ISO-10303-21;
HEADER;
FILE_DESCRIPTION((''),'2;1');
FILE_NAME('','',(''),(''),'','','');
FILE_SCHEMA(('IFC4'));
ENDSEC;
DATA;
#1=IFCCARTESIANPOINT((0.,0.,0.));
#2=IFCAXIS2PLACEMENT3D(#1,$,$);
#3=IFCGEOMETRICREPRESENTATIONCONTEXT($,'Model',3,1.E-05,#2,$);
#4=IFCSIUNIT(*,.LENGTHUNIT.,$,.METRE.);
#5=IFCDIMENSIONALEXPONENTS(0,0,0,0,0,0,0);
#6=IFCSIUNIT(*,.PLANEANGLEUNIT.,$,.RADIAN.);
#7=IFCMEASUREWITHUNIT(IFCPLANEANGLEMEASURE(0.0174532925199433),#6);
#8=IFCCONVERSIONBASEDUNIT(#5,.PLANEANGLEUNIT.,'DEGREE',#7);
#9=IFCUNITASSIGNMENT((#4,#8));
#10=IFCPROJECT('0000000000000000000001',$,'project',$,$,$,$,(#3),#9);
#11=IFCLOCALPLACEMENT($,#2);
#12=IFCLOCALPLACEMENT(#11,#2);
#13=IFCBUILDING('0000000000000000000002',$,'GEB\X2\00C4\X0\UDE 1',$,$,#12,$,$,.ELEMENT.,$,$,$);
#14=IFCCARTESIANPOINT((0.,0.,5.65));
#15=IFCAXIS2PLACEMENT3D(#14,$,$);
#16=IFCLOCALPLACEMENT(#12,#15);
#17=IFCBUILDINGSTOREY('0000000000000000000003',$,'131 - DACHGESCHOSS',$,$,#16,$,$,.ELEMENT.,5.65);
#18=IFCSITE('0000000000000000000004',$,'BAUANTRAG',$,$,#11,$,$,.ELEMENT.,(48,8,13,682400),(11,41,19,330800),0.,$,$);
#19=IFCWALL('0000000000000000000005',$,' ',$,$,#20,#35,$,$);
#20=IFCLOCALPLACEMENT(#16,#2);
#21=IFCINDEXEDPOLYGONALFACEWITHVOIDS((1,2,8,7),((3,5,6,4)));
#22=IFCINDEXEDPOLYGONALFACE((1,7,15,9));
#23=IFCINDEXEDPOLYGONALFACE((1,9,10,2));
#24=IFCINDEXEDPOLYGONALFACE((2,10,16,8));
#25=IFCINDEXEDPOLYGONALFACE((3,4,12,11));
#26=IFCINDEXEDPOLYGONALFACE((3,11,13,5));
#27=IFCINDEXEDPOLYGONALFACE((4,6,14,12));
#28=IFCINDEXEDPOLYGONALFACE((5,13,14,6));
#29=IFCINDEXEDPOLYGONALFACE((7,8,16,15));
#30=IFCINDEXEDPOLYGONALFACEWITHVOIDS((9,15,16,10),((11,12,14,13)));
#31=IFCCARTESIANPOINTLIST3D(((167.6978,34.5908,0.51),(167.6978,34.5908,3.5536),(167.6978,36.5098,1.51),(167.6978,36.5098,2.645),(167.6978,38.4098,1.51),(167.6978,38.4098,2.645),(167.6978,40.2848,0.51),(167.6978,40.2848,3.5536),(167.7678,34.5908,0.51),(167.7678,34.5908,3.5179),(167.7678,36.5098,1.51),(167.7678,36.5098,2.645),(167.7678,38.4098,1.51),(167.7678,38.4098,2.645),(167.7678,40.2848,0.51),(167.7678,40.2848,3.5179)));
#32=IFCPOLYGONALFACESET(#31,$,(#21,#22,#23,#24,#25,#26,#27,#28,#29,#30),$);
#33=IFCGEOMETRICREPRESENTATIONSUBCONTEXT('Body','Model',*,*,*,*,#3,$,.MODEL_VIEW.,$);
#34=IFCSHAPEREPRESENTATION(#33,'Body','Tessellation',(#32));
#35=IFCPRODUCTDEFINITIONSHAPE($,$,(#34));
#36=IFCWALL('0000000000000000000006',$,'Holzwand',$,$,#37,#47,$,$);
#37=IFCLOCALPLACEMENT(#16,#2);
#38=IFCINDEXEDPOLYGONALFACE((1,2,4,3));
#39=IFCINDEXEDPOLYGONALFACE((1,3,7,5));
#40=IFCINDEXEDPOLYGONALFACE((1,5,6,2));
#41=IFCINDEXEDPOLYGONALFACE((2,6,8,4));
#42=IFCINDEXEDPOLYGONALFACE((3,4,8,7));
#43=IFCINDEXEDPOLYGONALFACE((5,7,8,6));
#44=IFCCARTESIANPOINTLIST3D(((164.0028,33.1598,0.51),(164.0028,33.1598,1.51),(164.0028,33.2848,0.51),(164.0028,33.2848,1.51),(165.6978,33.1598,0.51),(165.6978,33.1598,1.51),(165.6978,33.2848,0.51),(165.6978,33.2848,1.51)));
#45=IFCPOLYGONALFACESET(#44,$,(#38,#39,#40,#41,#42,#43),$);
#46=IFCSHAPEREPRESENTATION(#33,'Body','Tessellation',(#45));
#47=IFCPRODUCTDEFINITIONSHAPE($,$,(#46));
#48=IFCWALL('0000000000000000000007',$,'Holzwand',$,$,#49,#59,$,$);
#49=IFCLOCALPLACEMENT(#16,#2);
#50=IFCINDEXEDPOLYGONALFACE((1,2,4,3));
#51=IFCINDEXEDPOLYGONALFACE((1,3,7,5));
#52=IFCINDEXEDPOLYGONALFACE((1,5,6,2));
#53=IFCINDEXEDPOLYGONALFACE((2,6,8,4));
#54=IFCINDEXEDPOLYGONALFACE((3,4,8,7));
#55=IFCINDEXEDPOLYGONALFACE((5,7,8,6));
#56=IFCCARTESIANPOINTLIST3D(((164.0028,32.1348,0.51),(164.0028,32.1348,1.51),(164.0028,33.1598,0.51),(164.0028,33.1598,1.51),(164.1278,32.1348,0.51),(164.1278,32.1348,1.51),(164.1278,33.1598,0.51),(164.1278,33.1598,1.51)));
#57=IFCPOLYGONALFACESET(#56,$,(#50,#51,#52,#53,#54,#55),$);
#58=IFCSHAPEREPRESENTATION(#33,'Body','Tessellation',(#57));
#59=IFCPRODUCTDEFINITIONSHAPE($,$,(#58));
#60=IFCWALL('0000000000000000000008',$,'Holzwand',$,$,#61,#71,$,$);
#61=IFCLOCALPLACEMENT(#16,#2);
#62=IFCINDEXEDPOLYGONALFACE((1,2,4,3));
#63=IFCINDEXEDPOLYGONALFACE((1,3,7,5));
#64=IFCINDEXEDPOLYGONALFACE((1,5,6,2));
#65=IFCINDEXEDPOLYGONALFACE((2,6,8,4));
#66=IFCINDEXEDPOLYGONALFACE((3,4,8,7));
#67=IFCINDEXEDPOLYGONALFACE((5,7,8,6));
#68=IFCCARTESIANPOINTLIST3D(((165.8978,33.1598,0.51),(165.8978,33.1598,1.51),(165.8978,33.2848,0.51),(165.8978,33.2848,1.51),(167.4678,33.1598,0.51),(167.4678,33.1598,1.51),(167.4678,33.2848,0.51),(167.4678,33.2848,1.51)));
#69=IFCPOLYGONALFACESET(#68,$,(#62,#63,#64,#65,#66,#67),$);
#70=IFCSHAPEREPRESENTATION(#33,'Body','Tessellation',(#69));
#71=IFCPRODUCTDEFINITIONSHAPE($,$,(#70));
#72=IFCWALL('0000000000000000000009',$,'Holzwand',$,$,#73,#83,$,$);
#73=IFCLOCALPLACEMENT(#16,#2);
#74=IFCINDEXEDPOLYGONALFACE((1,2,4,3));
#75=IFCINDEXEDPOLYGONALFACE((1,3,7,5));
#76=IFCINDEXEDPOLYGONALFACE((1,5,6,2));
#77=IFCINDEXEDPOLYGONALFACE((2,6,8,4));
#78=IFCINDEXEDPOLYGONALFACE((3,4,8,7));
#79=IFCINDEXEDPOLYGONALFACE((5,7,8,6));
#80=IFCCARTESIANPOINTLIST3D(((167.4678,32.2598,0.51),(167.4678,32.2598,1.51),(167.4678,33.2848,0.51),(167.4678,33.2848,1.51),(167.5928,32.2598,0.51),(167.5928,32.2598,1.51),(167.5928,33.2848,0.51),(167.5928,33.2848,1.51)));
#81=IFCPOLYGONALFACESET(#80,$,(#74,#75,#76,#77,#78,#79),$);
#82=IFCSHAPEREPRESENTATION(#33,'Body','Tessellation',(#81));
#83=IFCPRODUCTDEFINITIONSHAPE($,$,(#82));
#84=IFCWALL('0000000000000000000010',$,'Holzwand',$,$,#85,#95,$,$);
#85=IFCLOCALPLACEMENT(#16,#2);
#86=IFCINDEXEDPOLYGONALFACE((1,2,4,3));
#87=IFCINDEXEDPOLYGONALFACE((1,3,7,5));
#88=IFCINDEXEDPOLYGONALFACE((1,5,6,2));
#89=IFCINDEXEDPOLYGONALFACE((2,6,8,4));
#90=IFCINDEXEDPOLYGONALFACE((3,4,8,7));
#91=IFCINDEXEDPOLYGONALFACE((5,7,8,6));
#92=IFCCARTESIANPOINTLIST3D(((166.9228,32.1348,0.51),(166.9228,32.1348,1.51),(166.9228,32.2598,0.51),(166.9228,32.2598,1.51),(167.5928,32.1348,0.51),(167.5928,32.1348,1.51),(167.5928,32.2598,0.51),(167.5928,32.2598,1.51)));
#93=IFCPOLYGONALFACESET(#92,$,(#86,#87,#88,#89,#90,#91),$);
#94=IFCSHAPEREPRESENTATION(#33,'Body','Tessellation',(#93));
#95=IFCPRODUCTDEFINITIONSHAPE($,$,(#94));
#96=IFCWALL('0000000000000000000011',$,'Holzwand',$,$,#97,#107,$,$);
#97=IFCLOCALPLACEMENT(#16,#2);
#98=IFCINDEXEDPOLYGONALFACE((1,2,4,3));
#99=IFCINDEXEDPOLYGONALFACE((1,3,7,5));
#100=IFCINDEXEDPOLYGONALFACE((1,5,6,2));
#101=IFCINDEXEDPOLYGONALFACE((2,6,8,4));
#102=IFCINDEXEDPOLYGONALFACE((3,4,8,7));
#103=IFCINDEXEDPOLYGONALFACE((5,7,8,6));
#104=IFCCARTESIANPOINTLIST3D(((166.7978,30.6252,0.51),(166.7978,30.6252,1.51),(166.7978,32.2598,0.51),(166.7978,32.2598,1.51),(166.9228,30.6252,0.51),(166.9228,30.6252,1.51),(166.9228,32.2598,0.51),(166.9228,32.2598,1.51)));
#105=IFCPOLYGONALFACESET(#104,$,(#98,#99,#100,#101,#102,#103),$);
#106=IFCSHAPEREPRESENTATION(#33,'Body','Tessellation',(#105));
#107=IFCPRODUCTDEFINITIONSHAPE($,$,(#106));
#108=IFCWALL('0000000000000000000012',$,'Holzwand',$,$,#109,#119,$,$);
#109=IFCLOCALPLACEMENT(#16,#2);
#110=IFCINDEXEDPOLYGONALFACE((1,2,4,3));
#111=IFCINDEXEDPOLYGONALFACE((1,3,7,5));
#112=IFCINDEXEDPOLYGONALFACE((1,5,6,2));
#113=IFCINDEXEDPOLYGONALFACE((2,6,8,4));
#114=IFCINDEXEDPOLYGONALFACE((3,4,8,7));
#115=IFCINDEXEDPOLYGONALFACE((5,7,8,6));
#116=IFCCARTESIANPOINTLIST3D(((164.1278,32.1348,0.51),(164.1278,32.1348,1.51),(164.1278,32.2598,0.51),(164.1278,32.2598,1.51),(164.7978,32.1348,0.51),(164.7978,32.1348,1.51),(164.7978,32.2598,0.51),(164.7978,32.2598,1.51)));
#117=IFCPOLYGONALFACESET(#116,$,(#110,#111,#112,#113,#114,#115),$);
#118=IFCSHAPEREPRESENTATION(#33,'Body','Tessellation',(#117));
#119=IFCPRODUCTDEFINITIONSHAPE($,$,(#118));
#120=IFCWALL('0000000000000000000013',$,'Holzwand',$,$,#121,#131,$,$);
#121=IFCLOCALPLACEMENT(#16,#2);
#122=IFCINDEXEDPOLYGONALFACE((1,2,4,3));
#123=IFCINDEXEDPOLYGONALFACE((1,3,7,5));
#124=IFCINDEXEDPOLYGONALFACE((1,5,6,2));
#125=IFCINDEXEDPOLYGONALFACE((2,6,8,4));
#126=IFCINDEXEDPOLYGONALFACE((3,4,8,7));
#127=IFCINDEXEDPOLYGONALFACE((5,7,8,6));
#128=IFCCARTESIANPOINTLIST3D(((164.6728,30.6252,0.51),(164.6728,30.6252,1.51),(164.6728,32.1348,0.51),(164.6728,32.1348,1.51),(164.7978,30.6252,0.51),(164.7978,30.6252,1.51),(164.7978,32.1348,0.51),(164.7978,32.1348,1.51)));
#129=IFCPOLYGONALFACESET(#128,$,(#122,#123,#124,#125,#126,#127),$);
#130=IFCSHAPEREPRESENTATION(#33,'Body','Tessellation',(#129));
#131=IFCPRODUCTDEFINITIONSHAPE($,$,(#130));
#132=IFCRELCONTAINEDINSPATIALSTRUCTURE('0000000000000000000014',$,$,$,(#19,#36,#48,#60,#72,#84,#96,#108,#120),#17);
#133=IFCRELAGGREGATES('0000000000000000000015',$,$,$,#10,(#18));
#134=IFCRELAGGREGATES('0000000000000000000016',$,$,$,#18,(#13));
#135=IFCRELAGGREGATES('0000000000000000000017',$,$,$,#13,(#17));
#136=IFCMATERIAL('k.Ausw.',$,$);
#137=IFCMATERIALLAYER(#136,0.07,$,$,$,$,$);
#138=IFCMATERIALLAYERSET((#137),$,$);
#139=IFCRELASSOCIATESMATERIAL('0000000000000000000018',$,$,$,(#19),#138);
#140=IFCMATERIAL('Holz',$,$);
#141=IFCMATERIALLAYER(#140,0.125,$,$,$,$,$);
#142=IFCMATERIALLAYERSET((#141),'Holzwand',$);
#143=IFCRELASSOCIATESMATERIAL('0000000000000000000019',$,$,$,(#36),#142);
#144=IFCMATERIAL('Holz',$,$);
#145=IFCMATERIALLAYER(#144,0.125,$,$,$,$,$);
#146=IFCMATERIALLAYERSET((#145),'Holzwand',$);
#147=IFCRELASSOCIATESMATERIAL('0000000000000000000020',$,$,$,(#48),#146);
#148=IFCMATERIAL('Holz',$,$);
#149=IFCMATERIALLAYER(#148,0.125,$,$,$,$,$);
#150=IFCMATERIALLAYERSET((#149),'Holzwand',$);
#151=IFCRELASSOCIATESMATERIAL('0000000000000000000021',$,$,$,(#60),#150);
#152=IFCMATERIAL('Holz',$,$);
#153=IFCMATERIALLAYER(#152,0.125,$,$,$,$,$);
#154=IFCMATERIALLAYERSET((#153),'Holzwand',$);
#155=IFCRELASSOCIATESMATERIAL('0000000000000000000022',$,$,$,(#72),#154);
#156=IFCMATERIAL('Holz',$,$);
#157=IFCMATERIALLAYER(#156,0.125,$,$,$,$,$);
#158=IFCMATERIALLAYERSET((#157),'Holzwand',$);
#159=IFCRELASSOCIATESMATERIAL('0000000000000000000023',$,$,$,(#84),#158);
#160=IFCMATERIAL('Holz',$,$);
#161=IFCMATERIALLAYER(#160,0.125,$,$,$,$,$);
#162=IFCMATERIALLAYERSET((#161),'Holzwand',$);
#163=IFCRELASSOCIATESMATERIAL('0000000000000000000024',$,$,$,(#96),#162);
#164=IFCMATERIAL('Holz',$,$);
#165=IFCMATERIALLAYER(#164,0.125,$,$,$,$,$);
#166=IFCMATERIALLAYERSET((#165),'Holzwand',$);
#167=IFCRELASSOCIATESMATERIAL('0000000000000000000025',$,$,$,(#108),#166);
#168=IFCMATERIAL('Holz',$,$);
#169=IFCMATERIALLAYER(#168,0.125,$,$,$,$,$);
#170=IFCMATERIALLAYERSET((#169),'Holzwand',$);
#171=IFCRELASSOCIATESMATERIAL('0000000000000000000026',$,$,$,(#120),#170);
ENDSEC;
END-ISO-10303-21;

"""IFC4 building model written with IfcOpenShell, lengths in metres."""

from ifc_helpers import new_model, entity, si_unit, converted_unit, frame, frame_2d, origin, origin_with_axes, place, context, subcontext, project, spatial, polyline, rectangle, outline, extrude, clip, halfspace, material, layer, layer_set, layer_usage, element, save


model = new_model("IFC4")

# Units and contexts
model_context = context("Model", 3, precision=1e-05, world=origin())
body_context = subcontext(model_context, "Body", "Model", "MODEL_VIEW")
ifc_project = project(units=[si_unit("LENGTHUNIT", "METRE"), converted_unit("PLANEANGLEUNIT", "DEGREE", entity("IfcPlaneAngleMeasure", 0.0174532925199433), si_unit("PLANEANGLEUNIT", "RADIAN"), dimensions=[0, 0, 0, 0, 0, 0, 0])], contexts=[model_context])

# Site, building, storey
site_placement = place(None, origin())
site = spatial("IfcSite", under=ifc_project, at=site_placement, Name="BAUANTRAG", CompositionType="ELEMENT", RefLatitude=(48, 8, 13, 682400), RefLongitude=(11, 41, 19, 330800), RefElevation=0.0)
building_placement = place(site_placement, origin())
building = spatial("IfcBuilding", under=site, at=building_placement, Name="GEBÄUDE 1", CompositionType="ELEMENT")
storey_placement = place(building_placement, frame((0.0, 0.0, 5.65)))
storey = spatial("IfcBuildingStorey", under=building, at=storey_placement, Name="131 - DACHGESCHOSS", CompositionType="ELEMENT", Elevation=5.65)

# Wall, opening
ifc_material_1 = material(Name="k.Ausw.")
ifc_layer_1 = layer(ifc_material_1, 0.07)
ifc_layer_set_1 = layer_set([ifc_layer_1])
ifc_layer_usage_1 = layer_usage(ifc_layer_set_1, "AXIS2", "POSITIVE", -0.07)
wall_1_placement = place(storey_placement, frame((167.7678, 34.5908, 0.51), z_axis=(0.0, 0.0, 1.0), x_axis=(0.0, 1.0, 0.0)))
wall_1 = element("IfcWall", 1, at=wall_1_placement, inside=storey, material=ifc_layer_usage_1, Name=" ", context=body_context, shape_type="Clipping", body=[
    clip(extrude(rectangle(XDim=5.694, YDim=0.07, at=frame_2d((2.847, 0.035), x_axis=(1.0, 0.0))), origin_with_axes(), (0.0, 0.0, 1.0), 3.0436), halfspace(frame((2.847, 0.035, 3.0257), z_axis=(0.0, 0.45399, -0.891007), x_axis=(1.0, 0.0, 0.0)), True)),
])
opening_1_placement = place(wall_1_placement, frame((3.819, 0.07, 1.0), z_axis=(0.0, -1.0, 0.0), x_axis=(0.0, 0.0, 1.0)))
element("IfcOpeningElement", 2, at=opening_1_placement, cuts=wall_1, ObjectType="Opening", context=body_context, shape_type="SweptSolid", body=[
    extrude(outline(polyline([(0.0, 1.9), (1.135, 1.9), (1.135, 0.0), (0.0, 0.0), (0.0, 1.9)])), origin_with_axes(), (0.0, 0.0, 1.0), 0.07),
])

# Walls
ifc_material_2 = material(Name="Holz")
ifc_layer_2 = layer(ifc_material_2, 0.125)
ifc_layer_set_2 = layer_set([ifc_layer_2], Name="Holzwand")
ifc_layer_usage_2 = layer_usage(ifc_layer_set_2, "AXIS2", "POSITIVE", 0.0)
wall_2_placement = place(storey_placement, frame((164.0028, 33.1598, 0.51)))
element("IfcWall", 3, at=wall_2_placement, inside=storey, material=ifc_layer_usage_2, Name="Holzwand", context=body_context, shape_type="SweptSolid", body=[
    extrude(rectangle(XDim=1.695, YDim=0.125, at=frame_2d((0.8475, 0.0625), x_axis=(1.0, 0.0))), origin_with_axes(), (0.0, 0.0, 1.0), 1.0),
])
ifc_material_3 = material(Name="Holz")
ifc_layer_3 = layer(ifc_material_3, 0.125)
ifc_layer_set_3 = layer_set([ifc_layer_3], Name="Holzwand")
ifc_layer_usage_3 = layer_usage(ifc_layer_set_3, "AXIS2", "POSITIVE", 0.0)
wall_3_placement = place(storey_placement, frame((164.1278, 32.1348, 0.51), z_axis=(0.0, 0.0, 1.0), x_axis=(0.0, 1.0, 0.0)))
element("IfcWall", 4, at=wall_3_placement, inside=storey, material=ifc_layer_usage_3, Name="Holzwand", context=body_context, shape_type="SweptSolid", body=[
    extrude(rectangle(XDim=1.025, YDim=0.125, at=frame_2d((0.5125, 0.0625), x_axis=(1.0, 0.0))), origin_with_axes(), (0.0, 0.0, 1.0), 1.0),
])
ifc_material_4 = material(Name="Holz")
ifc_layer_4 = layer(ifc_material_4, 0.125)
ifc_layer_set_4 = layer_set([ifc_layer_4], Name="Holzwand")
ifc_layer_usage_4 = layer_usage(ifc_layer_set_4, "AXIS2", "POSITIVE", 0.0)
wall_4_placement = place(storey_placement, frame((165.8978, 33.1598, 0.51)))
element("IfcWall", 5, at=wall_4_placement, inside=storey, material=ifc_layer_usage_4, Name="Holzwand", context=body_context, shape_type="SweptSolid", body=[
    extrude(rectangle(XDim=1.57, YDim=0.125, at=frame_2d((0.785, 0.0625), x_axis=(1.0, 0.0))), origin_with_axes(), (0.0, 0.0, 1.0), 1.0),
])
ifc_material_5 = material(Name="Holz")
ifc_layer_5 = layer(ifc_material_5, 0.125)
ifc_layer_set_5 = layer_set([ifc_layer_5], Name="Holzwand")
ifc_layer_usage_5 = layer_usage(ifc_layer_set_5, "AXIS2", "POSITIVE", 0.0)
wall_5_placement = place(storey_placement, frame((167.4678, 33.2848, 0.51), z_axis=(0.0, 0.0, 1.0), x_axis=(0.0, -1.0, 0.0)))
element("IfcWall", 6, at=wall_5_placement, inside=storey, material=ifc_layer_usage_5, Name="Holzwand", context=body_context, shape_type="SweptSolid", body=[
    extrude(rectangle(XDim=1.025, YDim=0.125, at=frame_2d((0.5125, 0.0625), x_axis=(1.0, 0.0))), origin_with_axes(), (0.0, 0.0, 1.0), 1.0),
])
ifc_material_6 = material(Name="Holz")
ifc_layer_6 = layer(ifc_material_6, 0.125)
ifc_layer_set_6 = layer_set([ifc_layer_6], Name="Holzwand")
ifc_layer_usage_6 = layer_usage(ifc_layer_set_6, "AXIS2", "POSITIVE", 0.0)
wall_6_placement = place(storey_placement, frame((167.5928, 32.2598, 0.51), z_axis=(0.0, 0.0, 1.0), x_axis=(-1.0, 0.0, 0.0)))
element("IfcWall", 7, at=wall_6_placement, inside=storey, material=ifc_layer_usage_6, Name="Holzwand", context=body_context, shape_type="SweptSolid", body=[
    extrude(rectangle(XDim=0.67, YDim=0.125, at=frame_2d((0.335, 0.0625), x_axis=(1.0, 0.0))), origin_with_axes(), (0.0, 0.0, 1.0), 1.0),
])
ifc_material_7 = material(Name="Holz")
ifc_layer_7 = layer(ifc_material_7, 0.125)
ifc_layer_set_7 = layer_set([ifc_layer_7], Name="Holzwand")
ifc_layer_usage_7 = layer_usage(ifc_layer_set_7, "AXIS2", "POSITIVE", 0.0)
wall_7_placement = place(storey_placement, frame((166.7978, 32.2598, 0.51), z_axis=(0.0, 0.0, 1.0), x_axis=(0.0, -1.0, 0.0)))
element("IfcWall", 8, at=wall_7_placement, inside=storey, material=ifc_layer_usage_7, Name="Holzwand", context=body_context, shape_type="SweptSolid", body=[
    extrude(rectangle(XDim=1.6346, YDim=0.125, at=frame_2d((0.8173, 0.0625), x_axis=(1.0, 0.0))), origin_with_axes(), (0.0, 0.0, 1.0), 1.0),
])
ifc_material_8 = material(Name="Holz")
ifc_layer_8 = layer(ifc_material_8, 0.125)
ifc_layer_set_8 = layer_set([ifc_layer_8], Name="Holzwand")
ifc_layer_usage_8 = layer_usage(ifc_layer_set_8, "AXIS2", "POSITIVE", 0.0)
wall_8_placement = place(storey_placement, frame((164.7978, 32.2598, 0.51), z_axis=(0.0, 0.0, 1.0), x_axis=(-1.0, 0.0, 0.0)))
element("IfcWall", 9, at=wall_8_placement, inside=storey, material=ifc_layer_usage_8, Name="Holzwand", context=body_context, shape_type="SweptSolid", body=[
    extrude(rectangle(XDim=0.67, YDim=0.125, at=frame_2d((0.335, 0.0625), x_axis=(1.0, 0.0))), origin_with_axes(), (0.0, 0.0, 1.0), 1.0),
])
ifc_material_9 = material(Name="Holz")
ifc_layer_9 = layer(ifc_material_9, 0.125)
ifc_layer_set_9 = layer_set([ifc_layer_9], Name="Holzwand")
ifc_layer_usage_9 = layer_usage(ifc_layer_set_9, "AXIS2", "POSITIVE", 0.0)
wall_9_placement = place(storey_placement, frame((164.7978, 30.6252, 0.51), z_axis=(0.0, 0.0, 1.0), x_axis=(0.0, 1.0, 0.0)))
element("IfcWall", 10, at=wall_9_placement, inside=storey, material=ifc_layer_usage_9, Name="Holzwand", context=body_context, shape_type="SweptSolid", body=[
    extrude(rectangle(XDim=1.5096, YDim=0.125, at=frame_2d((0.7548, 0.0625), x_axis=(1.0, 0.0))), origin_with_axes(), (0.0, 0.0, 1.0), 1.0),
])

save(model, "model.ifc")
